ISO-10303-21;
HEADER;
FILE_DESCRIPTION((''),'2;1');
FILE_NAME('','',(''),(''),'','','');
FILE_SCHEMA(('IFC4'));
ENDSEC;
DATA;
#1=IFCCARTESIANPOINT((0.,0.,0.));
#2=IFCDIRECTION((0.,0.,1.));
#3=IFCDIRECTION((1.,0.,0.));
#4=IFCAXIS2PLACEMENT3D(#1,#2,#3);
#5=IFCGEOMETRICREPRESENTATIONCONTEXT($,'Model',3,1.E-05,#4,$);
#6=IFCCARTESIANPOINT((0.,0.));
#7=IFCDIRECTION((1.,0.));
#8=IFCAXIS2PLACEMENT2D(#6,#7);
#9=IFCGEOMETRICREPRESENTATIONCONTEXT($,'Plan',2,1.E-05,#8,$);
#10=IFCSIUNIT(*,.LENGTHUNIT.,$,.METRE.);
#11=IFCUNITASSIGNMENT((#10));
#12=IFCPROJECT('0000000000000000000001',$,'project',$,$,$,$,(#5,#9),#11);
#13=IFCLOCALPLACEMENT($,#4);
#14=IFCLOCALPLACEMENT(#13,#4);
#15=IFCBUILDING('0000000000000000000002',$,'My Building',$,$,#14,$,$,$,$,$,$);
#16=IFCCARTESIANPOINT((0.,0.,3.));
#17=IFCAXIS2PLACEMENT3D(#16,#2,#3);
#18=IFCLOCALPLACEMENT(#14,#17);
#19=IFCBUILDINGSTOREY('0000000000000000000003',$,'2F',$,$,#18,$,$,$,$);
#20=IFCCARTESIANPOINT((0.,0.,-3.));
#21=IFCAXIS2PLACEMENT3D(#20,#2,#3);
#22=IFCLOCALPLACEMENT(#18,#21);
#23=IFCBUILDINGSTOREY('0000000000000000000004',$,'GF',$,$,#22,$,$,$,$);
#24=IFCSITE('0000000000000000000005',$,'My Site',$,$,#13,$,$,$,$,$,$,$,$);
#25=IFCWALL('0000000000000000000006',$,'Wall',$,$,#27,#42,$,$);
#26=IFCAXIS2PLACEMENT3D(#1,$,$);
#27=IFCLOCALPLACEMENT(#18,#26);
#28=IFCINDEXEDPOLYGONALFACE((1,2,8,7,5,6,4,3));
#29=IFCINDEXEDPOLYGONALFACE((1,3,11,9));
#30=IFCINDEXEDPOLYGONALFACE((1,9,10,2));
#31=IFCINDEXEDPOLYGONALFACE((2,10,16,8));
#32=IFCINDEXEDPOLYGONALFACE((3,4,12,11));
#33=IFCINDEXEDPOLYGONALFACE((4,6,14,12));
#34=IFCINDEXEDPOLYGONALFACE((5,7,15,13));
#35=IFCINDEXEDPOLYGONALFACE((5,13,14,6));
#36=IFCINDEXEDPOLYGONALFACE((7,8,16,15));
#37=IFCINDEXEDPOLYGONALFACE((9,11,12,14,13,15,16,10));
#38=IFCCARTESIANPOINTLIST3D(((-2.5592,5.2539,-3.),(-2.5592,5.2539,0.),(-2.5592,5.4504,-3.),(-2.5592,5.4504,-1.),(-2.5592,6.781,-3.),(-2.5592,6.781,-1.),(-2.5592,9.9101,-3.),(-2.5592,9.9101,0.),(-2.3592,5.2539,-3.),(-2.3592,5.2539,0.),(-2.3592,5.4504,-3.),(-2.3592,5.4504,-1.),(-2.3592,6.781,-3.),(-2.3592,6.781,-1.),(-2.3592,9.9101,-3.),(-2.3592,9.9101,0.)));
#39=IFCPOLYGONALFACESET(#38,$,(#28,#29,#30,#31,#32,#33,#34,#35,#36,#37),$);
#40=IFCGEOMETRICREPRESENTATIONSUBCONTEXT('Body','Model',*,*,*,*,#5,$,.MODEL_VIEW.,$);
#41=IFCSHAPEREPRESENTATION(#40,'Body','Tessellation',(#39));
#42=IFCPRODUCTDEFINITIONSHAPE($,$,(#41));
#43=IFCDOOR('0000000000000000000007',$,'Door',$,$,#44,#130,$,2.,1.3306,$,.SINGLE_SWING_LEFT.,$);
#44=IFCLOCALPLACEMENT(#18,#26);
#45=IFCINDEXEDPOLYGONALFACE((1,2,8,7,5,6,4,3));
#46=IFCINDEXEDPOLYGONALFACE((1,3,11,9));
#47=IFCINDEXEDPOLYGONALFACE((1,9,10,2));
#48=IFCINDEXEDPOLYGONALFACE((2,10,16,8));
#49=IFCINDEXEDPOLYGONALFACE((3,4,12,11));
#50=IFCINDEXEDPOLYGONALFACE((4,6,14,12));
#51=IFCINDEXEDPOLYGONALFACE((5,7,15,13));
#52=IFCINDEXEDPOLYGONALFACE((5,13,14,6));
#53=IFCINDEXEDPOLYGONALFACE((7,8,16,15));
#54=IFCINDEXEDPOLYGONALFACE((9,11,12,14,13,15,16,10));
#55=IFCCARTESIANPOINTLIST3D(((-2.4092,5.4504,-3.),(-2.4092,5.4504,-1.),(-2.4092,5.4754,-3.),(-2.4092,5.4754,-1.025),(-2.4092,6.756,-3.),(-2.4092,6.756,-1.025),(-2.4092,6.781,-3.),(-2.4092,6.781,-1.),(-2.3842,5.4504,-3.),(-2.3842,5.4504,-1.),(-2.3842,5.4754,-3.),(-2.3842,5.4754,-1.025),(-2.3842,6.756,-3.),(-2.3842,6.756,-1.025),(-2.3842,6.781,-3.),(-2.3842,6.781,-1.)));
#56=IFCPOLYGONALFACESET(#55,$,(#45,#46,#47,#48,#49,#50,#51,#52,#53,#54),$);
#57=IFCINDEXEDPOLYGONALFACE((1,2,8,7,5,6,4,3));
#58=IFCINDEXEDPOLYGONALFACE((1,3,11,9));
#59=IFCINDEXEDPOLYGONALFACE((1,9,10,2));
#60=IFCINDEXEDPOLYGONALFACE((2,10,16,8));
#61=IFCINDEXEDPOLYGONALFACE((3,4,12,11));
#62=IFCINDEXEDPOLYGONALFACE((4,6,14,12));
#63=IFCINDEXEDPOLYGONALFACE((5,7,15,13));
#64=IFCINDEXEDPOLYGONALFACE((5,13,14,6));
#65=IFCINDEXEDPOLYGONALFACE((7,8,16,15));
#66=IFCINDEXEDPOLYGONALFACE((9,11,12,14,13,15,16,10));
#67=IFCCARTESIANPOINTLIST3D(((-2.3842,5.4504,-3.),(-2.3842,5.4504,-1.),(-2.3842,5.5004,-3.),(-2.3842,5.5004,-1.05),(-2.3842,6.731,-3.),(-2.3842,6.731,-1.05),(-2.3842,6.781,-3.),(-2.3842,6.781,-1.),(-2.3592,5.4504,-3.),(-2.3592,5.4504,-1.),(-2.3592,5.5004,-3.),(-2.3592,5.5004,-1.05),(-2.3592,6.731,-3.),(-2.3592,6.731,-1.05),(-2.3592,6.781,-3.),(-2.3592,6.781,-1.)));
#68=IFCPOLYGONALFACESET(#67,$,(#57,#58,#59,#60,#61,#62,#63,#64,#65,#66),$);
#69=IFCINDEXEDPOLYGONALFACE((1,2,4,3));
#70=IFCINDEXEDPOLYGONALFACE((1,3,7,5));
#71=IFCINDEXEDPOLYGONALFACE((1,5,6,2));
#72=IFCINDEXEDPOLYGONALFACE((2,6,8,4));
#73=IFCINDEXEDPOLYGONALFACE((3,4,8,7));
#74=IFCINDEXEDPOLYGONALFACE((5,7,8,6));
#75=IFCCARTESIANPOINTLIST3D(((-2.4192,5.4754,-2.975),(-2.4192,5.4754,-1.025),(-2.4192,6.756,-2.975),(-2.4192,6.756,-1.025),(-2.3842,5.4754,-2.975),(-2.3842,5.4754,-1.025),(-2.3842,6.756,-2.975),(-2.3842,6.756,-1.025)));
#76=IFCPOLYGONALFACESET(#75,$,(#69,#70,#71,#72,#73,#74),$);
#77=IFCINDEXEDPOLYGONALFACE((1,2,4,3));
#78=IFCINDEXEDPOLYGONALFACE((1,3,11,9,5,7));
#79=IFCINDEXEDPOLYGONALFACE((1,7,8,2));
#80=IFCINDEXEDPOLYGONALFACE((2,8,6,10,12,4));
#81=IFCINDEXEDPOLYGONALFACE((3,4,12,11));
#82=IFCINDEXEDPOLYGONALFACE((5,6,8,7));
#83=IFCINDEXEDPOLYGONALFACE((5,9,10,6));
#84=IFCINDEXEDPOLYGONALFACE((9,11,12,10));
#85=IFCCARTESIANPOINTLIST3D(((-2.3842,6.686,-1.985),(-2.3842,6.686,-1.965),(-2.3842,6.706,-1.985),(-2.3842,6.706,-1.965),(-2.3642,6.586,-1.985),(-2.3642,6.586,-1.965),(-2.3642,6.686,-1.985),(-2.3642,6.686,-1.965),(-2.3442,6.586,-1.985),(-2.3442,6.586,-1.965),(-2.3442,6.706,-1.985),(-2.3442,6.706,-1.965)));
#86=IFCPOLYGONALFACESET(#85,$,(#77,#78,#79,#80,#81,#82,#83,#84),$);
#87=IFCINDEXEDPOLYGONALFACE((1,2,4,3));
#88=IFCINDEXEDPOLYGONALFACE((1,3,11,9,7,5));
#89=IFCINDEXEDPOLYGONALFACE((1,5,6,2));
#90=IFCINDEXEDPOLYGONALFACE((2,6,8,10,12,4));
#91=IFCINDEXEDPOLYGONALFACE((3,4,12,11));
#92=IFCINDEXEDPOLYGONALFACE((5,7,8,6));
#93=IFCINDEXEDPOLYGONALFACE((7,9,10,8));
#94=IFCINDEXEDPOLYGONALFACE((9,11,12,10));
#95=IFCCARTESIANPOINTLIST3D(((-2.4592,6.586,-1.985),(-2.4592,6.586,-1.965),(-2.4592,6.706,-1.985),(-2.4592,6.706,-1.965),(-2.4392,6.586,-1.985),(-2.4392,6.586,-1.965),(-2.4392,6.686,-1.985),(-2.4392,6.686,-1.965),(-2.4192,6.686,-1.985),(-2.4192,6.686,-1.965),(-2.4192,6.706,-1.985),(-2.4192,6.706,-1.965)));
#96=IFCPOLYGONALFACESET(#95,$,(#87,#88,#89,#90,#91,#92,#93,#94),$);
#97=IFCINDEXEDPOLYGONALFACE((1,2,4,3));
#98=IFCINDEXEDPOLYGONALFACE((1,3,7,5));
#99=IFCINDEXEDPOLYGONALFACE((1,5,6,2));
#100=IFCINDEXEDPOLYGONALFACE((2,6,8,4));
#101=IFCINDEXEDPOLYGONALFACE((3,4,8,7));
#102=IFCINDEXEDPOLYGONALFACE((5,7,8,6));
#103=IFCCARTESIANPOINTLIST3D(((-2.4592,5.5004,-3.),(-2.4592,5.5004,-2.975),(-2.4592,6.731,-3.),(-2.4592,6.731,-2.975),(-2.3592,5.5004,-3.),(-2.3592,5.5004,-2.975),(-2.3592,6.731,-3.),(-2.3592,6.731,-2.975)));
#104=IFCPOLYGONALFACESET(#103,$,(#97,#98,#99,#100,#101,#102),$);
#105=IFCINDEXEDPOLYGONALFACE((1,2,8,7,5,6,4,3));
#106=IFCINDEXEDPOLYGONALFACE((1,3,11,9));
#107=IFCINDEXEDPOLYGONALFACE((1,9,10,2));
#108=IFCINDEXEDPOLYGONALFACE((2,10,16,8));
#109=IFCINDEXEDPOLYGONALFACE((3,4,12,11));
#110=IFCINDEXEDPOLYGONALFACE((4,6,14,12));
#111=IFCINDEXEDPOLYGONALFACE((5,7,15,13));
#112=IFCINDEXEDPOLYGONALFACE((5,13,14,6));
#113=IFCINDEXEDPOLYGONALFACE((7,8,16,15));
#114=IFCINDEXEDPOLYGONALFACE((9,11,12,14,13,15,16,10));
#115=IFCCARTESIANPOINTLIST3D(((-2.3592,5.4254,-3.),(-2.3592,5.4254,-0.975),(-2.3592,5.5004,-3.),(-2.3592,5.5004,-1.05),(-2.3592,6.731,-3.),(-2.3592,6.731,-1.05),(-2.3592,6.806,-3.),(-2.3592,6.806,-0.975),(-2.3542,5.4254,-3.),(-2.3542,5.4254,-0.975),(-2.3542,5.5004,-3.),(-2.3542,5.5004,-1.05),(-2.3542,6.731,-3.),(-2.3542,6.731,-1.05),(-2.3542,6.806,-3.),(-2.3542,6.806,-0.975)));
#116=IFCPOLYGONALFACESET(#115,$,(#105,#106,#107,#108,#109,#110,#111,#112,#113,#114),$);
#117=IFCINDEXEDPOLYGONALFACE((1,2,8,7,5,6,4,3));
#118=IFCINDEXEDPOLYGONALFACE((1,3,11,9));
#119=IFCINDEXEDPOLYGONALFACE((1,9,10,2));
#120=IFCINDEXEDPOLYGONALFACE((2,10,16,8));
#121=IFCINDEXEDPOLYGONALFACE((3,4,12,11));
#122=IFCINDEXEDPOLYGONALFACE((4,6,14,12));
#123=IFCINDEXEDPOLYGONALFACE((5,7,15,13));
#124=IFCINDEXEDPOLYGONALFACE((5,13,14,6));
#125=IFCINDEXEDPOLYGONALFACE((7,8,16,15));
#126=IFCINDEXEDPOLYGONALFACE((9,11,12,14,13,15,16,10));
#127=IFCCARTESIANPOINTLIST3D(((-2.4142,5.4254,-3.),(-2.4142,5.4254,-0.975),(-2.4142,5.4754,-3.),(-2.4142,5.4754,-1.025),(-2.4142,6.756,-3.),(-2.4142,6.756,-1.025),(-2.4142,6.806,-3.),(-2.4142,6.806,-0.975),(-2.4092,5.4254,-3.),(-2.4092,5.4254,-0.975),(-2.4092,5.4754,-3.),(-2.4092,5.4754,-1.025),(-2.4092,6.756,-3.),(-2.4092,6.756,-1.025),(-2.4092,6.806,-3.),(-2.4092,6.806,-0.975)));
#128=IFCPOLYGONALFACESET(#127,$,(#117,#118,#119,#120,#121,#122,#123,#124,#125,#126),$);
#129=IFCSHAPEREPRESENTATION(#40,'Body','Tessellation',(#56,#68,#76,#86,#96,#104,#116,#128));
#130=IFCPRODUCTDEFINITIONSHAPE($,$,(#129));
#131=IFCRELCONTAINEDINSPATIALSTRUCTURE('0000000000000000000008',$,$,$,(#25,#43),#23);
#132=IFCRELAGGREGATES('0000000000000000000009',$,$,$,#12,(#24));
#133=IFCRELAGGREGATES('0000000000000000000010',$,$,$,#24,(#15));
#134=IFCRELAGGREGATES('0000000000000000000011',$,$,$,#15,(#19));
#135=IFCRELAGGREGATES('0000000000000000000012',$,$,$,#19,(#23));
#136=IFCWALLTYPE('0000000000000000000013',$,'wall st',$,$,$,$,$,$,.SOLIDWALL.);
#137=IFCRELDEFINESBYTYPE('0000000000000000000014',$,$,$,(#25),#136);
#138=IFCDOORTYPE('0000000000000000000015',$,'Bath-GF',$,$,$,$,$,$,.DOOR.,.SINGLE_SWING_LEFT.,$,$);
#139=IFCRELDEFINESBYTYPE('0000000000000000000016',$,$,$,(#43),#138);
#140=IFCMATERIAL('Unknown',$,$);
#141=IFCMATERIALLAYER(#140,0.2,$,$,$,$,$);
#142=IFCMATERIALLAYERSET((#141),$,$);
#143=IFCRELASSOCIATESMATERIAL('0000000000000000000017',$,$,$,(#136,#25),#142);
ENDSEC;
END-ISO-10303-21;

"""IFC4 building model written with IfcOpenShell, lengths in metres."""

from ifc_helpers import new_model, entity, si_unit, frame, origin_with_axes, origin_2d_with_axis, place, context, subcontext, project, spatial, line, indexed_curve, outline, extrude, shape, source, transform, mapped, material, layer, layer_set, layer_usage, type_object, type_shapes, element, fill, save


model = new_model("IFC4")

# Units and contexts
model_context = context("Model", 3, precision=1e-05, world=origin_with_axes())
plan_context = context("Plan", 2, precision=1e-05, world=origin_2d_with_axis())
body_context_1 = subcontext(model_context, "Body", "Model", "MODEL_VIEW")
body_context_2 = subcontext(plan_context, "Body", "Plan", "PLAN_VIEW")
ifc_project = project(units=[si_unit("LENGTHUNIT", "METRE")], contexts=[model_context, plan_context])

# Site, building, storeys
site_placement = place(None, origin_with_axes())
site = spatial("IfcSite", under=ifc_project, at=site_placement, Name="My Site")
building_placement = place(site_placement, origin_with_axes())
building = spatial("IfcBuilding", under=site, at=building_placement, Name="My Building")
storey_1_placement = place(building_placement, frame((0.0, 0.0, 3.0), z_axis=(0.0, 0.0, 1.0), x_axis=(1.0, 0.0, 0.0)))
storey_1 = spatial("IfcBuildingStorey", under=building, at=storey_1_placement, Name="2F")
storey_2_placement = place(storey_1_placement, frame((0.0, 0.0, -3.0), z_axis=(0.0, 0.0, 1.0), x_axis=(1.0, 0.0, 0.0)))
storey_2 = spatial("IfcBuildingStorey", under=storey_1, at=storey_2_placement, Name="GF")

# Shared definitions
ifc_material = material(Name="Unknown")

# Shared definitions
ifc_layer = layer(ifc_material, 0.2)
ifc_layer_set = layer_set([ifc_layer])
wall_type = type_object("IfcWallType", Name="wall st", PredefinedType="SOLIDWALL", material=ifc_layer_set)

# Wall, opening, door
ifc_layer_usage_1 = layer_usage(ifc_layer_set, "AXIS2", "POSITIVE", 0.0)
wall_1_placement = place(storey_2_placement, frame((-2.5592, 10.1101, 0.0), z_axis=(0.0, 0.0, 1.0), x_axis=(0.0, -1.0, 0.0)))
wall_1 = element("IfcWall", 1, at=wall_1_placement, inside=storey_2, type_object=wall_type, material=ifc_layer_usage_1, Name="Wall", context=body_context_1, shape_type="SweptSolid", body=[
    extrude(outline(indexed_curve([(0.2, 0.0), (0.2, 0.2), (4.8561, 0.2), (4.8561, 0.0)], segments=[line(1, 2, 3, 4, 1)])), origin_with_axes(), (0.0, 0.0, 1.0), 3.0),
])
shared_shape_1 = source(origin_with_axes(), body_context_1, "Body", "SweptSolid", [
    extrude(outline(indexed_curve([(0.0, 0.0), (1.3306, 0.0), (1.3306, 2.0), (0.0, 2.0)], segments=[line(1, 2, 3, 4, 1)])), frame((0.0, -0.6, 0.0), z_axis=(0.0, -1.0, 0.0), x_axis=(1.0, 0.0, 0.0)), (0.0, 0.0, -1.0), 1.2),
])
opening_1_placement = place(wall_1_placement, frame((4.6597, 0.2, 0.0), z_axis=(0.0, 0.0, 1.0), x_axis=(-1.0, 0.0, 0.0)))
opening_1 = element("IfcOpeningElement", 2, at=opening_1_placement, cuts=wall_1, PredefinedType="OPENING", context=body_context_1, shape_type="MappedRepresentation", body=[
    mapped(shared_shape_1, transform((0.0, 0.0, 0.0), x_axis=(1.0, 0.0, 0.0), y_axis=(0.0, 1.0, 0.0), z_axis=(0.0, 0.0, 1.0), scale=1.0)),
])
door_type_1 = type_object("IfcDoorType", Name="Bath-GF", OperationType="SINGLE_SWING_LEFT", PredefinedType="DOOR")
shared_shape_2 = source(origin_with_axes(), body_context_1, "Body", "SweptSolid", [
    extrude(outline(indexed_curve([(0.0, 0.0), (0.0, 2.0), (1.3306, 2.0), (1.3306, 0.0), (1.3056, 0.0), (1.3056, 1.975), (0.025, 1.975), (0.025, 0.0)], segments=[line(1, 2, 3, 4, 5, 6, 7, 8, 1)])), frame((0.0, 0.025, 0.0), z_axis=(0.0, -1.0, 0.0), x_axis=(1.0, 0.0, 0.0)), (0.0, 0.0, -1.0), 0.025),
    extrude(outline(indexed_curve([(0.0, 0.0), (0.0, 2.0), (1.3306, 2.0), (1.3306, 0.0), (1.2806, 0.0), (1.2806, 1.95), (0.05, 1.95), (0.05, 0.0)], segments=[line(1, 2, 3, 4, 5, 6, 7, 8, 1)])), frame((0.0, 0.0, 0.0), z_axis=(0.0, -1.0, 0.0), x_axis=(1.0, 0.0, 0.0)), (0.0, 0.0, -1.0), 0.025),
    extrude(outline(indexed_curve([(0.0, 0.0), (1.2806, 0.0), (1.2806, 0.035), (0.0, 0.035)], segments=[line(1, 2, 3, 4, 1)])), frame((0.025, 0.025, 0.025), z_axis=(0.0, 0.0, 1.0), x_axis=(1.0, 0.0, 0.0)), (0.0, 0.0, 1.0), 1.95),
    extrude(outline(indexed_curve([(0.0, 0.0), (0.0, -0.04), (-0.12, -0.04), (-0.12, -0.02), (-0.02, -0.02), (-0.02, 0.0)], segments=[line(1, 2, 3, 4, 5, 6, 1)])), frame((1.2556, 0.025, 1.015), z_axis=(0.0, 0.0, 1.0), x_axis=(1.0, 0.0, 0.0)), (0.0, 0.0, 1.0), 0.02),
    extrude(outline(indexed_curve([(0.0, 0.0), (0.0, 0.04), (-0.12, 0.04), (-0.12, 0.02), (-0.02, 0.02), (-0.02, 0.0)], segments=[line(1, 2, 3, 4, 5, 6, 1)])), frame((1.2556, 0.06, 1.015), z_axis=(0.0, 0.0, 1.0), x_axis=(1.0, 0.0, 0.0)), (0.0, 0.0, 1.0), 0.02),
    extrude(outline(indexed_curve([(0.0, 0.0), (1.2306, 0.0), (1.2306, 0.1), (0.0, 0.1)], segments=[line(1, 2, 3, 4, 1)])), frame((0.05, 0.0, 0.0), z_axis=(0.0, 0.0, 1.0), x_axis=(1.0, 0.0, 0.0)), (0.0, 0.0, 1.0), 0.025),
    extrude(outline(indexed_curve([(0.0, 0.0), (0.0, 2.025), (1.3806, 2.025), (1.3806, 0.0), (1.3056, 0.0), (1.3056, 1.95), (0.075, 1.95), (0.075, 0.0)], segments=[line(1, 2, 3, 4, 5, 6, 7, 8, 1)])), frame((-0.025, -0.005, 0.0), z_axis=(0.0, -1.0, 0.0), x_axis=(1.0, 0.0, 0.0)), (0.0, 0.0, -1.0), 0.005),
    extrude(outline(indexed_curve([(0.0, 0.0), (0.0, 2.025), (1.3806, 2.025), (1.3806, 0.0), (1.3306, 0.0), (1.3306, 1.975), (0.05, 1.975), (0.05, 0.0)], segments=[line(1, 2, 3, 4, 5, 6, 7, 8, 1)])), frame((-0.025, 0.05, 0.0), z_axis=(0.0, -1.0, 0.0), x_axis=(1.0, 0.0, 0.0)), (0.0, 0.0, -1.0), 0.005),
])
shared_shape_3 = source(origin_with_axes(), body_context_2, "Body", "Curve2D", [
    entity("IfcIndexedPolyCurve", entity("IfcCartesianPointList2D", [[0.0, 0.0], [0.0, 0.05], [0.025, 0.05], [0.025, 0.025], [0.05, 0.025], [0.05, 0.0]]), [entity("IfcLineIndex", [1, 2, 3, 4, 5, 6, 1])]),
    entity("IfcIndexedPolyCurve", entity("IfcCartesianPointList2D", [[1.3306, 0.0], [1.3306, 0.05], [1.3056, 0.05], [1.3056, 0.025], [1.2806, 0.025], [1.2806, 0.0]]), [entity("IfcLineIndex", [1, 2, 3, 4, 5, 6, 1])]),
    entity("IfcTrimmedCurve", entity("IfcEllipse", entity("IfcAxis2Placement2D", entity("IfcCartesianPoint", [0.06, 0.05]), entity("IfcDirection", [1.0, 0.0])), 1.2456, 1.2806), [entity("IfcCartesianPoint", [1.3056, 0.05])], [entity("IfcCartesianPoint", [0.06, 1.3306])], True, "CARTESIAN"),
    entity("IfcIndexedPolyCurve", entity("IfcCartesianPointList2D", [[0.025, 0.05], [0.06, 0.05], [0.06, 1.3306], [0.025, 1.3306]]), [entity("IfcLineIndex", [1, 2, 3, 4, 1])]),
])
type_shapes(door_type_1, [shared_shape_2, shared_shape_3])
door_1_placement = place(opening_1_placement, frame((0.0, 0.0, 0.0), z_axis=(0.0, 0.0, 1.0), x_axis=(1.0, 0.0, 0.0)))
door_1 = element("IfcDoor", 3, at=door_1_placement, inside=storey_2, type_object=door_type_1, Name="Door", OperationType="SINGLE_SWING_LEFT", OverallHeight=2.0, OverallWidth=1.3306, shapes=[
    shape(body_context_1, "Body", "MappedRepresentation", [mapped(shared_shape_2, transform((0.0, 0.0, 0.0), x_axis=(1.0, 0.0, 0.0), y_axis=(0.0, 1.0, 0.0), z_axis=(0.0, 0.0, 1.0), scale=1.0))]),
    shape(body_context_2, "Body", "MappedRepresentation", [mapped(shared_shape_3, transform((0.0, 0.0, 0.0), x_axis=(1.0, 0.0, 0.0), y_axis=(0.0, 1.0, 0.0), z_axis=(0.0, 0.0, 1.0), scale=1.0))]),
])
fill(opening_1, door_1)

save(model, "model.ifc")
